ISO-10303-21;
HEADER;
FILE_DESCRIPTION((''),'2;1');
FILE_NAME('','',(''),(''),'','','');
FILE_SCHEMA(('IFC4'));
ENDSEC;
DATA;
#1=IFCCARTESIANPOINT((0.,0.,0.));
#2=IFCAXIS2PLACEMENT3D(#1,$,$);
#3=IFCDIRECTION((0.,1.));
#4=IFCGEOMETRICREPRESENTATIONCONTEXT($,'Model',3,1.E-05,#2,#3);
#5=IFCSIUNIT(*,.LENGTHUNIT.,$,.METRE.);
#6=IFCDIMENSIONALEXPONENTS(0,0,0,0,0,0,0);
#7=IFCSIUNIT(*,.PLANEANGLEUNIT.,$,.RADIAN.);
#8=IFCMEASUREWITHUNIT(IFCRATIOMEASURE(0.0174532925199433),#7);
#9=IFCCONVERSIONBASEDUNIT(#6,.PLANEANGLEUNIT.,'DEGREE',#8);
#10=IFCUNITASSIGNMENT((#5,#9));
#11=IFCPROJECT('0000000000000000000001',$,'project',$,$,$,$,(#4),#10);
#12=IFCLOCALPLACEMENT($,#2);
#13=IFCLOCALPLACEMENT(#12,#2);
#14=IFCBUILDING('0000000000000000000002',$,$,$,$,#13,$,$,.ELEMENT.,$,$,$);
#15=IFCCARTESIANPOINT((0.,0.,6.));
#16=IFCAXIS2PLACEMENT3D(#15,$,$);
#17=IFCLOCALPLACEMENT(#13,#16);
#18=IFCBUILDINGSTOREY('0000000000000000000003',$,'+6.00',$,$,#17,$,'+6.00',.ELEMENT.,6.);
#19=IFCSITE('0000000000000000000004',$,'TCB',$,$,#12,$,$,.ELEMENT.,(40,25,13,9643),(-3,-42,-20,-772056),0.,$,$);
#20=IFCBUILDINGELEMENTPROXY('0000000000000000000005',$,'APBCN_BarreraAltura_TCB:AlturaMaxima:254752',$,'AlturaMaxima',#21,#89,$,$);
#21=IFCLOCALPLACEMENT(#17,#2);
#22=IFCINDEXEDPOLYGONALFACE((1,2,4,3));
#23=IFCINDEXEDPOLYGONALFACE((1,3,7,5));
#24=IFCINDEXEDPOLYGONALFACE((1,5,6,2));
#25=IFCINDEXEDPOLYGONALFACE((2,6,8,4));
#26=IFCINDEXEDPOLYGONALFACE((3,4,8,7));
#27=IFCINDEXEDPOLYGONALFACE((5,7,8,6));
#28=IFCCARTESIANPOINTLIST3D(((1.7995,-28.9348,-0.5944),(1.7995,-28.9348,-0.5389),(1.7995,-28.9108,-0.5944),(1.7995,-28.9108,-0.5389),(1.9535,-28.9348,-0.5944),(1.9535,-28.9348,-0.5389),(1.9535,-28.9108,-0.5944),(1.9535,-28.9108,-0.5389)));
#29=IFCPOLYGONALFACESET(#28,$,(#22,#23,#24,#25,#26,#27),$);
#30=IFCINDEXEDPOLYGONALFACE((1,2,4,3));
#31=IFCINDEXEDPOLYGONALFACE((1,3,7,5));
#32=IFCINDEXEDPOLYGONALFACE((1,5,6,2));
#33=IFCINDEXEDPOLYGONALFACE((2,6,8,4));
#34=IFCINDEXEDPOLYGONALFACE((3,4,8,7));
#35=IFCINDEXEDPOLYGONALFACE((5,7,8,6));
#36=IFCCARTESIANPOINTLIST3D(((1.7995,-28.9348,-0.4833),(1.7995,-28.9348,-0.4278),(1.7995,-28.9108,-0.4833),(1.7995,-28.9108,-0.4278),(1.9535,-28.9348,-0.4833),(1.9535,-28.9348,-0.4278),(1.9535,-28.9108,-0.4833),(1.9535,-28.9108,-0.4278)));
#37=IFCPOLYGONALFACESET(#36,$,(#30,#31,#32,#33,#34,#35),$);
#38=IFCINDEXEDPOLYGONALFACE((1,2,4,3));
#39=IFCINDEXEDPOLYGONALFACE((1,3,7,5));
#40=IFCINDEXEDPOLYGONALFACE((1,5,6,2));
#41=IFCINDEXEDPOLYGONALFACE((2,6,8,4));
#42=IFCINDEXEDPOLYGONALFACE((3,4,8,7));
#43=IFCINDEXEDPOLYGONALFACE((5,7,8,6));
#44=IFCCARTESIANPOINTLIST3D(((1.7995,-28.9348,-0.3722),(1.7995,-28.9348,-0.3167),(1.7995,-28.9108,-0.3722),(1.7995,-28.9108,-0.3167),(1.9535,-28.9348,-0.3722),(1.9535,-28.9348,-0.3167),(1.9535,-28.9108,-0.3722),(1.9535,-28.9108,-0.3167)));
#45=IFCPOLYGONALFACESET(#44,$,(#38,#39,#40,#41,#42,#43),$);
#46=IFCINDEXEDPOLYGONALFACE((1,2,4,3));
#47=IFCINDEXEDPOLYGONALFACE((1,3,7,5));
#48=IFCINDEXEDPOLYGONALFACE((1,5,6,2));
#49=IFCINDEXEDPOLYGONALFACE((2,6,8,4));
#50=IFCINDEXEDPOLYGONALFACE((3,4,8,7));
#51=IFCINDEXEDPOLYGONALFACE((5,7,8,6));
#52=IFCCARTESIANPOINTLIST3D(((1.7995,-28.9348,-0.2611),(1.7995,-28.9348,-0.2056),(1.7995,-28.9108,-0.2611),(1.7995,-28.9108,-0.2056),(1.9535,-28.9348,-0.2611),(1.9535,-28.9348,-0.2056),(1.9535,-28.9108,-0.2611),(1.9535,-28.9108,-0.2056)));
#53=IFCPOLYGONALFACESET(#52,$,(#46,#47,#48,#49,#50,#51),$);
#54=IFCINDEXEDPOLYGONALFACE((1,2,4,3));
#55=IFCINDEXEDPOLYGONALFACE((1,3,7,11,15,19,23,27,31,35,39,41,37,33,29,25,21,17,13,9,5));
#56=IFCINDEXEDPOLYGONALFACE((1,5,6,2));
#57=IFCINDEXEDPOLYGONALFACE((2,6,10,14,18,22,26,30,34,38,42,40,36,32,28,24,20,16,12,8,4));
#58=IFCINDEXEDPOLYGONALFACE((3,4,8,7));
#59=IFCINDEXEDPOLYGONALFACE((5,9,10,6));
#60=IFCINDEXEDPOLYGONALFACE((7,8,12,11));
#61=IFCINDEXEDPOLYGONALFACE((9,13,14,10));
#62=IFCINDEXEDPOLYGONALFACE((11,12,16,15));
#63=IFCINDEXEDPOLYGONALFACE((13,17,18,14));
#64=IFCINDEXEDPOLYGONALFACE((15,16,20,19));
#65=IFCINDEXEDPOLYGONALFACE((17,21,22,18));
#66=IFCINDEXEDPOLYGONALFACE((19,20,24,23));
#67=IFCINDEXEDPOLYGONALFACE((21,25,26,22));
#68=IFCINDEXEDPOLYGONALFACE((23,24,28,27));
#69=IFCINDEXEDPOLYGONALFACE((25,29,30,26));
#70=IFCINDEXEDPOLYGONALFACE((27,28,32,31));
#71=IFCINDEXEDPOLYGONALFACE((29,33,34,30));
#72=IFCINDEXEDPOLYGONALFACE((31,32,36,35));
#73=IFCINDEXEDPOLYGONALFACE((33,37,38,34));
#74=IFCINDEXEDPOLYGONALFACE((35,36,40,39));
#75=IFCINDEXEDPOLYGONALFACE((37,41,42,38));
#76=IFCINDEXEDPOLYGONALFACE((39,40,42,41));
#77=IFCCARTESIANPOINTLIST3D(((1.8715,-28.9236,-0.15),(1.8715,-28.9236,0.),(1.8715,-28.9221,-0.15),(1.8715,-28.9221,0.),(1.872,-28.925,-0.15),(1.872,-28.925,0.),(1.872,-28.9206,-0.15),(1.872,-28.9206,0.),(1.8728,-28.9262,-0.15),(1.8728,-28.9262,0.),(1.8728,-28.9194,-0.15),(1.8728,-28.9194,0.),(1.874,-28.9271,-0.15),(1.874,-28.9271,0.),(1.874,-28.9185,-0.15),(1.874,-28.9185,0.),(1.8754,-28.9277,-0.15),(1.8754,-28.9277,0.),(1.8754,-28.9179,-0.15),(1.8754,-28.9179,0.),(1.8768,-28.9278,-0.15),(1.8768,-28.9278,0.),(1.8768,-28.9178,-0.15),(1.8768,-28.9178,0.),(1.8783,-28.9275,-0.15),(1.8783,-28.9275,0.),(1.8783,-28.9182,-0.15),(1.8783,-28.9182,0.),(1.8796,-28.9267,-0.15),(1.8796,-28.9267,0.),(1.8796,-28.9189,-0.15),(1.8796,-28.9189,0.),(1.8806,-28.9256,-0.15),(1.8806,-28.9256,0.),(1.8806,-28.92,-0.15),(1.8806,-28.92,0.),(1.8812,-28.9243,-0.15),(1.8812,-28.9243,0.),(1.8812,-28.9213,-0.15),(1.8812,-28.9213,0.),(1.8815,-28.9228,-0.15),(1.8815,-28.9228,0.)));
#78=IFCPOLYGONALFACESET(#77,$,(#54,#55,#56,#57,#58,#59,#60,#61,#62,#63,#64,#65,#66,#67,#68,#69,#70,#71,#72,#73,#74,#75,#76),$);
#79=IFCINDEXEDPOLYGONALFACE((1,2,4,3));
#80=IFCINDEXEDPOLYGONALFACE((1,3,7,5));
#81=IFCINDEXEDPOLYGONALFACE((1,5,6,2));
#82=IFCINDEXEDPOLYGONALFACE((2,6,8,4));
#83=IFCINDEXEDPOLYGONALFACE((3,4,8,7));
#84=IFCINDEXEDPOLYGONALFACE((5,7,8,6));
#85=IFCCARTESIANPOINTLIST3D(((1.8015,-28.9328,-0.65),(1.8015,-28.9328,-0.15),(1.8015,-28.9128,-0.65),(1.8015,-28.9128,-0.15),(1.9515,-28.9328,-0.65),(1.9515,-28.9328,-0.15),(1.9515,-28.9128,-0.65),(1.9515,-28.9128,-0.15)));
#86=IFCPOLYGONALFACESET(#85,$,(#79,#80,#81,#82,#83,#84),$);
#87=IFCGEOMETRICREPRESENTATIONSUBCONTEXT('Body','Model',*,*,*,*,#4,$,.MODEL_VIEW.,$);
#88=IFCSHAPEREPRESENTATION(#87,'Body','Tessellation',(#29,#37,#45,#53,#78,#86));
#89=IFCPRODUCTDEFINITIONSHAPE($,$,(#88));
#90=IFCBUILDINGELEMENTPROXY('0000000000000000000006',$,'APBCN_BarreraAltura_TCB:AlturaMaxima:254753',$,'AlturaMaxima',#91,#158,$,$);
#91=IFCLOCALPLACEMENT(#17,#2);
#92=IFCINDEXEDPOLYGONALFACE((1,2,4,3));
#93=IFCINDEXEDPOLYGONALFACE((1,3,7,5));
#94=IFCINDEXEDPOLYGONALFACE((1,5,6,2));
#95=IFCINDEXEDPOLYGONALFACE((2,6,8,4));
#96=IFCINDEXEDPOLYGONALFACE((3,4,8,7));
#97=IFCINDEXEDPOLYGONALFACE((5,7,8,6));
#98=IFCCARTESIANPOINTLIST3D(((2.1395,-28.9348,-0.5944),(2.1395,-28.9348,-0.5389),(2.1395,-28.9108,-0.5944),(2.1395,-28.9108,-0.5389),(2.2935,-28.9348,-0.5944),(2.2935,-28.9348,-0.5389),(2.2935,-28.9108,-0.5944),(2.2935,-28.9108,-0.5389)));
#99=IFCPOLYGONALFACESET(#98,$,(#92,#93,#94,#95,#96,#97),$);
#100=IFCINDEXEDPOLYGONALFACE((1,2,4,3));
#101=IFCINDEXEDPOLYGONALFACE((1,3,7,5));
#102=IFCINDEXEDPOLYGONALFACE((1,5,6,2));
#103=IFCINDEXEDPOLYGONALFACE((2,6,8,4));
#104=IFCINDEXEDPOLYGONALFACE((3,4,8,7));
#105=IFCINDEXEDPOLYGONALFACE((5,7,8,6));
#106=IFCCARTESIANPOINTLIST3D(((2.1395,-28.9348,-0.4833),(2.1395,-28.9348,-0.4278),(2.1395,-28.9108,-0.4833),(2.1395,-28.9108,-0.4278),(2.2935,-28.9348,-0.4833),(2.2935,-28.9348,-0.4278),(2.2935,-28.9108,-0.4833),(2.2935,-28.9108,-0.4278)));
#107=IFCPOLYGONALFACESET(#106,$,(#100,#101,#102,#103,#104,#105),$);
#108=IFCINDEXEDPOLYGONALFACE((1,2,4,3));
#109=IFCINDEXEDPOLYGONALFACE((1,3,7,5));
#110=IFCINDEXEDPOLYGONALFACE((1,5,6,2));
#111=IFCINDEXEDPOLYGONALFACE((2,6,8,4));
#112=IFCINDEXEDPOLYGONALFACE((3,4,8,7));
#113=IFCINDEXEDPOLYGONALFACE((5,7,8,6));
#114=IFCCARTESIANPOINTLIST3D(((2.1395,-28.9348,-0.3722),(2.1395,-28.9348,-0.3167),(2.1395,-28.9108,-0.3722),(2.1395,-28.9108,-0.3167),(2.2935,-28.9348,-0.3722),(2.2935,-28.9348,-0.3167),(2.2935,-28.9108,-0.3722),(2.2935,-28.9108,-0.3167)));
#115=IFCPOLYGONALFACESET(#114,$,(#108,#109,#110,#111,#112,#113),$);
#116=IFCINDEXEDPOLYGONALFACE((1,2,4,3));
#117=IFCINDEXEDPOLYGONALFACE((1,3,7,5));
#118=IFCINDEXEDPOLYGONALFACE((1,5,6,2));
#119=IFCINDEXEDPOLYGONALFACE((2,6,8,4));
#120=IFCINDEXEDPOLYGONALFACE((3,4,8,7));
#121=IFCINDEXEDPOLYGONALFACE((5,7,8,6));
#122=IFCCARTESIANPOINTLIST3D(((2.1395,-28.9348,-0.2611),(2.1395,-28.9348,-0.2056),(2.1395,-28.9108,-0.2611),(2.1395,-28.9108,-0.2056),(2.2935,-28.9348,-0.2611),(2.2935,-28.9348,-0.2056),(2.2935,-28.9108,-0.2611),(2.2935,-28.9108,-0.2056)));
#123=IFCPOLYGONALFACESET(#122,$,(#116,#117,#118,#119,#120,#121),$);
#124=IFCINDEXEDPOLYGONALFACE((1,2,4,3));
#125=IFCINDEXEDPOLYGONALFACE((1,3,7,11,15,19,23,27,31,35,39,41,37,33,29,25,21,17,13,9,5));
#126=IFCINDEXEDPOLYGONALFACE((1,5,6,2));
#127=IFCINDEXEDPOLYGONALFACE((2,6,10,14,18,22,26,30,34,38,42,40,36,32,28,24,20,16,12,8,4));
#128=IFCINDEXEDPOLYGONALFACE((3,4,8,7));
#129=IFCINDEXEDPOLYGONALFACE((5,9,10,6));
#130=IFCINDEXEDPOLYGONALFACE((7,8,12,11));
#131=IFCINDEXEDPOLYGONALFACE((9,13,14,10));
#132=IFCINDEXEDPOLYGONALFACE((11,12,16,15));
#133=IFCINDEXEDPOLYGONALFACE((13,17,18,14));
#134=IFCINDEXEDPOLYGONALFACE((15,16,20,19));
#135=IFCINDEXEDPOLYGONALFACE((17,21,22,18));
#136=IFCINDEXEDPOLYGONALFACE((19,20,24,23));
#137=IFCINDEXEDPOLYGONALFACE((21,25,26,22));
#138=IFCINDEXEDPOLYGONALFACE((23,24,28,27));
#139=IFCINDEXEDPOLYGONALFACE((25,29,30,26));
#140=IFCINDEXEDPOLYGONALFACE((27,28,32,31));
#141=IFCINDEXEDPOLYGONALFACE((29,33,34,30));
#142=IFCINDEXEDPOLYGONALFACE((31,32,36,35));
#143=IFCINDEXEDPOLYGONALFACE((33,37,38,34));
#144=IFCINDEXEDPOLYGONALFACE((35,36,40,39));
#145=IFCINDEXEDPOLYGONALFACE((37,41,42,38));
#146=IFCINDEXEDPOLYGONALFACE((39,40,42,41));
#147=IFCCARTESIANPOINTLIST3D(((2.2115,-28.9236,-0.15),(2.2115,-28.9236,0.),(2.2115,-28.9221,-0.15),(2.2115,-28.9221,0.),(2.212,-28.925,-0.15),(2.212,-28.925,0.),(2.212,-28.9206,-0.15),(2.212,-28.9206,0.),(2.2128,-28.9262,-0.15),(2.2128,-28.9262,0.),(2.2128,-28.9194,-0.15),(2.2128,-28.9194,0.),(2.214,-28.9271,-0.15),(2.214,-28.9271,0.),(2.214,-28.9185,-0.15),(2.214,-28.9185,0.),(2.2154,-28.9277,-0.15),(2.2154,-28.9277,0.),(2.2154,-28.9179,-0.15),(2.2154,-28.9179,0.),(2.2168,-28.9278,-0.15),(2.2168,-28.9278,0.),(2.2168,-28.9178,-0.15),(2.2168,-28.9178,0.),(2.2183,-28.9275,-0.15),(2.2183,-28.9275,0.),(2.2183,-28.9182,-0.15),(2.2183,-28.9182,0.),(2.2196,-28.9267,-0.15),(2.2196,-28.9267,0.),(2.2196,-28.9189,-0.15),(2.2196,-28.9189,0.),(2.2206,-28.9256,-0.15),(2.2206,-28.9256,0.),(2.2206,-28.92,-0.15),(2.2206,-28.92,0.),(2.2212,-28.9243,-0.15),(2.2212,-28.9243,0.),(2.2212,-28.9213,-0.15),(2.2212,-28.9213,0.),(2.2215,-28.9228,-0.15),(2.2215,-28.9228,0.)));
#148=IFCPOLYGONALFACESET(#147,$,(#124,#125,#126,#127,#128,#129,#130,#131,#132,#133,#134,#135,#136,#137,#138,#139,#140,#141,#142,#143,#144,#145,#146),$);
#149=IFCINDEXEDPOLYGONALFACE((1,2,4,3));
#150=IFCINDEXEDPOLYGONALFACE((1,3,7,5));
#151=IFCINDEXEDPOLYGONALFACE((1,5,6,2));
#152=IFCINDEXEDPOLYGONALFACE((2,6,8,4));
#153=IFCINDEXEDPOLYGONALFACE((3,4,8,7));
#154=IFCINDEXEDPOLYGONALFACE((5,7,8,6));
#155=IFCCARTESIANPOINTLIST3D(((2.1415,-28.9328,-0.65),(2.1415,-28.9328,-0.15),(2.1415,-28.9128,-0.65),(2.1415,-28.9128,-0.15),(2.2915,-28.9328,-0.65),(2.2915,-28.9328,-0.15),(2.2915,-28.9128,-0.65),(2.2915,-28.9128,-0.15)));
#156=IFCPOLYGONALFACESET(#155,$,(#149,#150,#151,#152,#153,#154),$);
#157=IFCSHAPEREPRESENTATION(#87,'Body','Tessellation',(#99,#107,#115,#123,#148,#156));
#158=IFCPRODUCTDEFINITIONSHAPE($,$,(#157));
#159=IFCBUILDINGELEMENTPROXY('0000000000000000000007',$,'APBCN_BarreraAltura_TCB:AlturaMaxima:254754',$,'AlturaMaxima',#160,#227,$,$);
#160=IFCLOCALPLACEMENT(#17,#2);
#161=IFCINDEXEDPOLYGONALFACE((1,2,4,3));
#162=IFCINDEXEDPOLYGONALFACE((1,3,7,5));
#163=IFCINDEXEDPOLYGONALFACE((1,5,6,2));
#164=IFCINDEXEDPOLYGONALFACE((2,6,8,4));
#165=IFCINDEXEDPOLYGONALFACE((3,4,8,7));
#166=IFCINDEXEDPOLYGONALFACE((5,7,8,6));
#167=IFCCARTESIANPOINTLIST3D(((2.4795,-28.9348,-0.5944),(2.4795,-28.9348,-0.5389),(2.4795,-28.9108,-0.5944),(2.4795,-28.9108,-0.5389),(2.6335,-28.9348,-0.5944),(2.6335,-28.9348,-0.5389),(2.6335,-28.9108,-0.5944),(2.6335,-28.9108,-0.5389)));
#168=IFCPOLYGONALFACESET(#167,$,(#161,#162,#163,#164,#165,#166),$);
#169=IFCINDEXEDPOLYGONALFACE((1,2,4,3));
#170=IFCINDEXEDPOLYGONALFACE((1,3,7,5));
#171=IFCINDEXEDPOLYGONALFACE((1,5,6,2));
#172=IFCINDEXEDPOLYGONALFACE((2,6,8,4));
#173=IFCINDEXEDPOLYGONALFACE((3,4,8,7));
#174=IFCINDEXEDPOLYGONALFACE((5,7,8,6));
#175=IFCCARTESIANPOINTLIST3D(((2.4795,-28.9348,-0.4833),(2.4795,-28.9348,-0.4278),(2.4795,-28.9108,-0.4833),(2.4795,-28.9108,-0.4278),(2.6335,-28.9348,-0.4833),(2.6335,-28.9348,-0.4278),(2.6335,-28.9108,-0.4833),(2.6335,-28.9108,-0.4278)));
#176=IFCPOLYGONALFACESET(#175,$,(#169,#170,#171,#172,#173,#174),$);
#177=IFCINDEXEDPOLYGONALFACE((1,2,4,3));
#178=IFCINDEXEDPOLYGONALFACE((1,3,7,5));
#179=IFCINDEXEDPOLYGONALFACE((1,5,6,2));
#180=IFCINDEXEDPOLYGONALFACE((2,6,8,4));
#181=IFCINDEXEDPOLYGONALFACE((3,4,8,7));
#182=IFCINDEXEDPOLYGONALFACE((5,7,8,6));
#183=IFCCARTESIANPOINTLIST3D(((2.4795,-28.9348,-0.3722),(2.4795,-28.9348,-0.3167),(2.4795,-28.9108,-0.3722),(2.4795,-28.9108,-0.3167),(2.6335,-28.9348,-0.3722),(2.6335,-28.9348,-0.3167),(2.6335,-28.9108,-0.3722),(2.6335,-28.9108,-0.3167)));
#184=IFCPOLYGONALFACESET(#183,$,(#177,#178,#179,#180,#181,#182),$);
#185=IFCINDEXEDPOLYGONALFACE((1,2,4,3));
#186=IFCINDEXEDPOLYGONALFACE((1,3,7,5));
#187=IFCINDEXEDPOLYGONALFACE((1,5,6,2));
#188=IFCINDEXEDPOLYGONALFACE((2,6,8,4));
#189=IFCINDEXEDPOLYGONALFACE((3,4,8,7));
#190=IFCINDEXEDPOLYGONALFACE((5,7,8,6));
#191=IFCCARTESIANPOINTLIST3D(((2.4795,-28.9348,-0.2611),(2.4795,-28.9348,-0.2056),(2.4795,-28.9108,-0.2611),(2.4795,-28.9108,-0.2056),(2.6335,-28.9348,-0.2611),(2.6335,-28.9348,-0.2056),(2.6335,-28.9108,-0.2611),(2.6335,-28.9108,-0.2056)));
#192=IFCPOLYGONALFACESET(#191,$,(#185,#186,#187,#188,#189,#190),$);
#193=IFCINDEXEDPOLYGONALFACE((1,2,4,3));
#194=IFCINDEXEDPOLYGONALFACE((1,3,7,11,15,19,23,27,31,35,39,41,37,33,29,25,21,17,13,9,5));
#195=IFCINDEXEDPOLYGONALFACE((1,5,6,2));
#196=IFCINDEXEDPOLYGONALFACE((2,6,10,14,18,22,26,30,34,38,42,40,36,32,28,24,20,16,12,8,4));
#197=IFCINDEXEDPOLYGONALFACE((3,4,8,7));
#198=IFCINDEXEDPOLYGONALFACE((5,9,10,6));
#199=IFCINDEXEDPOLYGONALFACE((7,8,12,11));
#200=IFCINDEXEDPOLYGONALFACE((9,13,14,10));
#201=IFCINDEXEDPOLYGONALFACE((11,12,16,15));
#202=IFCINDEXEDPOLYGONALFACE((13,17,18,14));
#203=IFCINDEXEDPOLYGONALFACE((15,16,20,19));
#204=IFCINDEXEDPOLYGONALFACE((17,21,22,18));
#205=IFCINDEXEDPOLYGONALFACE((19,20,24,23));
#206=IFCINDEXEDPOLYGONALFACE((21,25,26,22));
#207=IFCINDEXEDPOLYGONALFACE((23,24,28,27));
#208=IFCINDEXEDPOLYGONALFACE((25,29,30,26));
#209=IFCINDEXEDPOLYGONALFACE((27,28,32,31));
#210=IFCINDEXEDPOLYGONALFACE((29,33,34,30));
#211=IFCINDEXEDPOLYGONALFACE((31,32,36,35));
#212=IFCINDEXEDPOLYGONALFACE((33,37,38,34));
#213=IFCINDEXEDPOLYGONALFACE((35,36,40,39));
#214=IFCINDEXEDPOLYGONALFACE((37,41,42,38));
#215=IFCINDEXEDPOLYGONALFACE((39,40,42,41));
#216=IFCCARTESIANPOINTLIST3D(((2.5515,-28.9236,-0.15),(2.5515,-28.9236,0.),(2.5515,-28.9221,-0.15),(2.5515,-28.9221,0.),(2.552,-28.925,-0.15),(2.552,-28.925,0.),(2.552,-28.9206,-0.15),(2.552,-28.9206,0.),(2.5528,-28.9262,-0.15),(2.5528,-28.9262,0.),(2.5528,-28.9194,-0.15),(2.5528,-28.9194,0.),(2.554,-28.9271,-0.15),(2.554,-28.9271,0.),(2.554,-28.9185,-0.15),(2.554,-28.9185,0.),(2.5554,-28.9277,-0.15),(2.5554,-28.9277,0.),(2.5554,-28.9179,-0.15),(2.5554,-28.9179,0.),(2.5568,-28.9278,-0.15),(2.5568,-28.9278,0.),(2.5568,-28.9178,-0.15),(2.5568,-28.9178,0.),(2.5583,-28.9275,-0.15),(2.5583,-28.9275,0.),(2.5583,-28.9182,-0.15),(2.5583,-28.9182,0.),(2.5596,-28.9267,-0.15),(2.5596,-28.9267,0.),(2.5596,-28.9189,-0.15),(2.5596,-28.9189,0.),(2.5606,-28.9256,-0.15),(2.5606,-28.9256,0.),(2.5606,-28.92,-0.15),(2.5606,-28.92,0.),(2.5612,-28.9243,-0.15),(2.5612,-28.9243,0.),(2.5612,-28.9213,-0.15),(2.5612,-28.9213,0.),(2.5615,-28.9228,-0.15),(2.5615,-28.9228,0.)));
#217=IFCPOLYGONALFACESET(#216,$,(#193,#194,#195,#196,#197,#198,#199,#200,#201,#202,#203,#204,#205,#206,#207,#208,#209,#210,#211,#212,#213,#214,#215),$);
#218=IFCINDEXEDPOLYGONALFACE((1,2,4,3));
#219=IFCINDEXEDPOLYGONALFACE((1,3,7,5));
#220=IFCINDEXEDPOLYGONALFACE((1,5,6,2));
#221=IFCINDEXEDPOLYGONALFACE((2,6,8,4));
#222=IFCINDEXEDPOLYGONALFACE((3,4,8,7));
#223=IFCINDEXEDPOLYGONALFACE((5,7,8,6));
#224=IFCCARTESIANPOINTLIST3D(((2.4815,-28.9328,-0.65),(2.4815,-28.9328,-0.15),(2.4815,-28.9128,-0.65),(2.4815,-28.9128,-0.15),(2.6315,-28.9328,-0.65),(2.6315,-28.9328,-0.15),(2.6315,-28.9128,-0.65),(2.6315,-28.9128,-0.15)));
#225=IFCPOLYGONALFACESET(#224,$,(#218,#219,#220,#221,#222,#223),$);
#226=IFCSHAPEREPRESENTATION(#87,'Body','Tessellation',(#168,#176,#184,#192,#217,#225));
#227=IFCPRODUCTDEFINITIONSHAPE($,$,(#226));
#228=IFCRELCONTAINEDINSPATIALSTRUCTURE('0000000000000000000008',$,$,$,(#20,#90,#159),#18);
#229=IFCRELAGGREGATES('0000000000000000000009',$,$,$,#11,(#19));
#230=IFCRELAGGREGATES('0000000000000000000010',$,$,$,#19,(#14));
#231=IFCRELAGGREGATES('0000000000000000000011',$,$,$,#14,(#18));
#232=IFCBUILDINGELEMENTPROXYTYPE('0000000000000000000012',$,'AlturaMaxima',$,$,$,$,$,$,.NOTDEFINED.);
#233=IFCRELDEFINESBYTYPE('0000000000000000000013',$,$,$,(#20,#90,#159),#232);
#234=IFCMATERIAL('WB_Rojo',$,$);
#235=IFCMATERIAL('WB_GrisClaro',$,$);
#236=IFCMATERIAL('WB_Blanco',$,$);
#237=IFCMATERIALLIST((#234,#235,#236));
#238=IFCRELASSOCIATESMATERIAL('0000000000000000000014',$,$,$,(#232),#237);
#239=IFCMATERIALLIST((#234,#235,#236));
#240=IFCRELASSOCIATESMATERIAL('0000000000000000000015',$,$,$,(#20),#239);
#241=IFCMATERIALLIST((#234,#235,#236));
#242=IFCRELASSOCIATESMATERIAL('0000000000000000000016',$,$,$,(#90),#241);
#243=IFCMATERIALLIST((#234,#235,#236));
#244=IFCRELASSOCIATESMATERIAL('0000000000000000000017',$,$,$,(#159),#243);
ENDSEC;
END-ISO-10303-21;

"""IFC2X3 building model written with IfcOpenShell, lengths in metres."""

from ifc_helpers import new_model, entity, si_unit, converted_unit, direction, frame, frame_2d, origin, origin_2d_with_axis, place, context, subcontext, project, spatial, rectangle, circle, extrude, source, transform, mapped, material, material_list, type_object, type_shapes, element, save


model = new_model("IFC2X3")

# Units and contexts
model_context = context("Model", 3, precision=1e-05, world=origin(), true_north=direction((0.0, 1.0)))
body_context = subcontext(model_context, "Body", "Model", "MODEL_VIEW")
ifc_project = project(units=[si_unit("LENGTHUNIT", "METRE"), converted_unit("PLANEANGLEUNIT", "DEGREE", entity("IfcRatioMeasure", 0.0174532925199433), si_unit("PLANEANGLEUNIT", "RADIAN"), dimensions=[0, 0, 0, 0, 0, 0, 0])], contexts=[model_context])

# Site, building, storey
site_placement = place(None, origin())
site = spatial("IfcSite", under=ifc_project, at=site_placement, Name="TCB", CompositionType="ELEMENT", RefLatitude=(40, 25, 13, 9643), RefLongitude=(-3, -42, -20, -772056), RefElevation=0.0)
building_placement = place(site_placement, origin())
building = spatial("IfcBuilding", under=site, at=building_placement, CompositionType="ELEMENT")
storey_placement = place(building_placement, frame((0.0, 0.0, 6.0)))
storey = spatial("IfcBuildingStorey", under=building, at=storey_placement, Name="+6.00", LongName="+6.00", CompositionType="ELEMENT", Elevation=6.0)

# Building element proxies
ifc_material_1 = material(Name="WB_Rojo")
ifc_material_2 = material(Name="WB_GrisClaro")
ifc_material_3 = material(Name="WB_Blanco")
ifc_material_list_1 = material_list([ifc_material_1, ifc_material_2, ifc_material_3])
ifc_material_list_2 = material_list([ifc_material_1, ifc_material_2, ifc_material_3])
building_element_proxy_type = type_object("IfcBuildingElementProxyType", Name="AlturaMaxima", PredefinedType="NOTDEFINED", material=ifc_material_list_2)
shared_shape = source(origin(), body_context, "Body", "SweptSolid", [
    extrude(rectangle(XDim=0.154, YDim=0.024, at=frame_2d((0.0, 0.0), x_axis=(1.0, 0.0))), frame((0.0, 0.0, -0.5944), z_axis=(0.0, 0.0, 1.0), x_axis=(-1.0, 0.0, 0.0)), (0.0, 0.0, 1.0), 0.0556),
    extrude(rectangle(XDim=0.154, YDim=0.024, at=frame_2d((0.0, 0.0), x_axis=(1.0, 0.0))), frame((0.0, 0.0, -0.4833), z_axis=(0.0, 0.0, 1.0), x_axis=(-1.0, 0.0, 0.0)), (0.0, 0.0, 1.0), 0.0556),
    extrude(rectangle(XDim=0.154, YDim=0.024, at=frame_2d((0.0, 0.0), x_axis=(1.0, 0.0))), frame((0.0, 0.0, -0.3722), z_axis=(0.0, 0.0, 1.0), x_axis=(-1.0, 0.0, 0.0)), (0.0, 0.0, 1.0), 0.0556),
    extrude(rectangle(XDim=0.154, YDim=0.024, at=frame_2d((0.0, 0.0), x_axis=(1.0, 0.0))), frame((0.0, 0.0, -0.2611), z_axis=(0.0, 0.0, 1.0), x_axis=(-1.0, 0.0, 0.0)), (0.0, 0.0, 1.0), 0.0556),
    extrude(circle(Radius=0.005, at=frame_2d((0.0, 0.0), x_axis=(1.0, 0.0))), frame((0.0, 0.0, -0.15)), (0.0, 0.0, 1.0), 0.15),
    extrude(rectangle(XDim=0.02, YDim=0.15, at=origin_2d_with_axis()), frame((0.0, 0.0, -0.65), z_axis=(0.0, 0.0, 1.0), x_axis=(0.0, 1.0, 0.0)), (0.0, 0.0, 1.0), 0.5),
])
type_shapes(building_element_proxy_type, [shared_shape])
proxy_1_placement = place(storey_placement, frame((1.8765, -28.9228, 0.0)))
element("IfcBuildingElementProxy", 1, at=proxy_1_placement, inside=storey, type_object=building_element_proxy_type, material=ifc_material_list_1, Name="APBCN_BarreraAltura_TCB:AlturaMaxima:254752", ObjectType="AlturaMaxima", context=body_context, shape_type="MappedRepresentation", body=[
    mapped(shared_shape, transform((0.0, 0.0, 0.0), scale=1.0)),
])
ifc_material_list_3 = material_list([ifc_material_1, ifc_material_2, ifc_material_3])
proxy_2_placement = place(storey_placement, frame((2.2165, -28.9228, 0.0)))
element("IfcBuildingElementProxy", 2, at=proxy_2_placement, inside=storey, type_object=building_element_proxy_type, material=ifc_material_list_3, Name="APBCN_BarreraAltura_TCB:AlturaMaxima:254753", ObjectType="AlturaMaxima", context=body_context, shape_type="MappedRepresentation", body=[
    mapped(shared_shape, transform((0.0, 0.0, 0.0), scale=1.0)),
])
ifc_material_list_4 = material_list([ifc_material_1, ifc_material_2, ifc_material_3])
proxy_3_placement = place(storey_placement, frame((2.5565, -28.9228, 0.0)))
element("IfcBuildingElementProxy", 3, at=proxy_3_placement, inside=storey, type_object=building_element_proxy_type, material=ifc_material_list_4, Name="APBCN_BarreraAltura_TCB:AlturaMaxima:254754", ObjectType="AlturaMaxima", context=body_context, shape_type="MappedRepresentation", body=[
    mapped(shared_shape, transform((0.0, 0.0, 0.0), scale=1.0)),
])

save(model, "model.ifc")
